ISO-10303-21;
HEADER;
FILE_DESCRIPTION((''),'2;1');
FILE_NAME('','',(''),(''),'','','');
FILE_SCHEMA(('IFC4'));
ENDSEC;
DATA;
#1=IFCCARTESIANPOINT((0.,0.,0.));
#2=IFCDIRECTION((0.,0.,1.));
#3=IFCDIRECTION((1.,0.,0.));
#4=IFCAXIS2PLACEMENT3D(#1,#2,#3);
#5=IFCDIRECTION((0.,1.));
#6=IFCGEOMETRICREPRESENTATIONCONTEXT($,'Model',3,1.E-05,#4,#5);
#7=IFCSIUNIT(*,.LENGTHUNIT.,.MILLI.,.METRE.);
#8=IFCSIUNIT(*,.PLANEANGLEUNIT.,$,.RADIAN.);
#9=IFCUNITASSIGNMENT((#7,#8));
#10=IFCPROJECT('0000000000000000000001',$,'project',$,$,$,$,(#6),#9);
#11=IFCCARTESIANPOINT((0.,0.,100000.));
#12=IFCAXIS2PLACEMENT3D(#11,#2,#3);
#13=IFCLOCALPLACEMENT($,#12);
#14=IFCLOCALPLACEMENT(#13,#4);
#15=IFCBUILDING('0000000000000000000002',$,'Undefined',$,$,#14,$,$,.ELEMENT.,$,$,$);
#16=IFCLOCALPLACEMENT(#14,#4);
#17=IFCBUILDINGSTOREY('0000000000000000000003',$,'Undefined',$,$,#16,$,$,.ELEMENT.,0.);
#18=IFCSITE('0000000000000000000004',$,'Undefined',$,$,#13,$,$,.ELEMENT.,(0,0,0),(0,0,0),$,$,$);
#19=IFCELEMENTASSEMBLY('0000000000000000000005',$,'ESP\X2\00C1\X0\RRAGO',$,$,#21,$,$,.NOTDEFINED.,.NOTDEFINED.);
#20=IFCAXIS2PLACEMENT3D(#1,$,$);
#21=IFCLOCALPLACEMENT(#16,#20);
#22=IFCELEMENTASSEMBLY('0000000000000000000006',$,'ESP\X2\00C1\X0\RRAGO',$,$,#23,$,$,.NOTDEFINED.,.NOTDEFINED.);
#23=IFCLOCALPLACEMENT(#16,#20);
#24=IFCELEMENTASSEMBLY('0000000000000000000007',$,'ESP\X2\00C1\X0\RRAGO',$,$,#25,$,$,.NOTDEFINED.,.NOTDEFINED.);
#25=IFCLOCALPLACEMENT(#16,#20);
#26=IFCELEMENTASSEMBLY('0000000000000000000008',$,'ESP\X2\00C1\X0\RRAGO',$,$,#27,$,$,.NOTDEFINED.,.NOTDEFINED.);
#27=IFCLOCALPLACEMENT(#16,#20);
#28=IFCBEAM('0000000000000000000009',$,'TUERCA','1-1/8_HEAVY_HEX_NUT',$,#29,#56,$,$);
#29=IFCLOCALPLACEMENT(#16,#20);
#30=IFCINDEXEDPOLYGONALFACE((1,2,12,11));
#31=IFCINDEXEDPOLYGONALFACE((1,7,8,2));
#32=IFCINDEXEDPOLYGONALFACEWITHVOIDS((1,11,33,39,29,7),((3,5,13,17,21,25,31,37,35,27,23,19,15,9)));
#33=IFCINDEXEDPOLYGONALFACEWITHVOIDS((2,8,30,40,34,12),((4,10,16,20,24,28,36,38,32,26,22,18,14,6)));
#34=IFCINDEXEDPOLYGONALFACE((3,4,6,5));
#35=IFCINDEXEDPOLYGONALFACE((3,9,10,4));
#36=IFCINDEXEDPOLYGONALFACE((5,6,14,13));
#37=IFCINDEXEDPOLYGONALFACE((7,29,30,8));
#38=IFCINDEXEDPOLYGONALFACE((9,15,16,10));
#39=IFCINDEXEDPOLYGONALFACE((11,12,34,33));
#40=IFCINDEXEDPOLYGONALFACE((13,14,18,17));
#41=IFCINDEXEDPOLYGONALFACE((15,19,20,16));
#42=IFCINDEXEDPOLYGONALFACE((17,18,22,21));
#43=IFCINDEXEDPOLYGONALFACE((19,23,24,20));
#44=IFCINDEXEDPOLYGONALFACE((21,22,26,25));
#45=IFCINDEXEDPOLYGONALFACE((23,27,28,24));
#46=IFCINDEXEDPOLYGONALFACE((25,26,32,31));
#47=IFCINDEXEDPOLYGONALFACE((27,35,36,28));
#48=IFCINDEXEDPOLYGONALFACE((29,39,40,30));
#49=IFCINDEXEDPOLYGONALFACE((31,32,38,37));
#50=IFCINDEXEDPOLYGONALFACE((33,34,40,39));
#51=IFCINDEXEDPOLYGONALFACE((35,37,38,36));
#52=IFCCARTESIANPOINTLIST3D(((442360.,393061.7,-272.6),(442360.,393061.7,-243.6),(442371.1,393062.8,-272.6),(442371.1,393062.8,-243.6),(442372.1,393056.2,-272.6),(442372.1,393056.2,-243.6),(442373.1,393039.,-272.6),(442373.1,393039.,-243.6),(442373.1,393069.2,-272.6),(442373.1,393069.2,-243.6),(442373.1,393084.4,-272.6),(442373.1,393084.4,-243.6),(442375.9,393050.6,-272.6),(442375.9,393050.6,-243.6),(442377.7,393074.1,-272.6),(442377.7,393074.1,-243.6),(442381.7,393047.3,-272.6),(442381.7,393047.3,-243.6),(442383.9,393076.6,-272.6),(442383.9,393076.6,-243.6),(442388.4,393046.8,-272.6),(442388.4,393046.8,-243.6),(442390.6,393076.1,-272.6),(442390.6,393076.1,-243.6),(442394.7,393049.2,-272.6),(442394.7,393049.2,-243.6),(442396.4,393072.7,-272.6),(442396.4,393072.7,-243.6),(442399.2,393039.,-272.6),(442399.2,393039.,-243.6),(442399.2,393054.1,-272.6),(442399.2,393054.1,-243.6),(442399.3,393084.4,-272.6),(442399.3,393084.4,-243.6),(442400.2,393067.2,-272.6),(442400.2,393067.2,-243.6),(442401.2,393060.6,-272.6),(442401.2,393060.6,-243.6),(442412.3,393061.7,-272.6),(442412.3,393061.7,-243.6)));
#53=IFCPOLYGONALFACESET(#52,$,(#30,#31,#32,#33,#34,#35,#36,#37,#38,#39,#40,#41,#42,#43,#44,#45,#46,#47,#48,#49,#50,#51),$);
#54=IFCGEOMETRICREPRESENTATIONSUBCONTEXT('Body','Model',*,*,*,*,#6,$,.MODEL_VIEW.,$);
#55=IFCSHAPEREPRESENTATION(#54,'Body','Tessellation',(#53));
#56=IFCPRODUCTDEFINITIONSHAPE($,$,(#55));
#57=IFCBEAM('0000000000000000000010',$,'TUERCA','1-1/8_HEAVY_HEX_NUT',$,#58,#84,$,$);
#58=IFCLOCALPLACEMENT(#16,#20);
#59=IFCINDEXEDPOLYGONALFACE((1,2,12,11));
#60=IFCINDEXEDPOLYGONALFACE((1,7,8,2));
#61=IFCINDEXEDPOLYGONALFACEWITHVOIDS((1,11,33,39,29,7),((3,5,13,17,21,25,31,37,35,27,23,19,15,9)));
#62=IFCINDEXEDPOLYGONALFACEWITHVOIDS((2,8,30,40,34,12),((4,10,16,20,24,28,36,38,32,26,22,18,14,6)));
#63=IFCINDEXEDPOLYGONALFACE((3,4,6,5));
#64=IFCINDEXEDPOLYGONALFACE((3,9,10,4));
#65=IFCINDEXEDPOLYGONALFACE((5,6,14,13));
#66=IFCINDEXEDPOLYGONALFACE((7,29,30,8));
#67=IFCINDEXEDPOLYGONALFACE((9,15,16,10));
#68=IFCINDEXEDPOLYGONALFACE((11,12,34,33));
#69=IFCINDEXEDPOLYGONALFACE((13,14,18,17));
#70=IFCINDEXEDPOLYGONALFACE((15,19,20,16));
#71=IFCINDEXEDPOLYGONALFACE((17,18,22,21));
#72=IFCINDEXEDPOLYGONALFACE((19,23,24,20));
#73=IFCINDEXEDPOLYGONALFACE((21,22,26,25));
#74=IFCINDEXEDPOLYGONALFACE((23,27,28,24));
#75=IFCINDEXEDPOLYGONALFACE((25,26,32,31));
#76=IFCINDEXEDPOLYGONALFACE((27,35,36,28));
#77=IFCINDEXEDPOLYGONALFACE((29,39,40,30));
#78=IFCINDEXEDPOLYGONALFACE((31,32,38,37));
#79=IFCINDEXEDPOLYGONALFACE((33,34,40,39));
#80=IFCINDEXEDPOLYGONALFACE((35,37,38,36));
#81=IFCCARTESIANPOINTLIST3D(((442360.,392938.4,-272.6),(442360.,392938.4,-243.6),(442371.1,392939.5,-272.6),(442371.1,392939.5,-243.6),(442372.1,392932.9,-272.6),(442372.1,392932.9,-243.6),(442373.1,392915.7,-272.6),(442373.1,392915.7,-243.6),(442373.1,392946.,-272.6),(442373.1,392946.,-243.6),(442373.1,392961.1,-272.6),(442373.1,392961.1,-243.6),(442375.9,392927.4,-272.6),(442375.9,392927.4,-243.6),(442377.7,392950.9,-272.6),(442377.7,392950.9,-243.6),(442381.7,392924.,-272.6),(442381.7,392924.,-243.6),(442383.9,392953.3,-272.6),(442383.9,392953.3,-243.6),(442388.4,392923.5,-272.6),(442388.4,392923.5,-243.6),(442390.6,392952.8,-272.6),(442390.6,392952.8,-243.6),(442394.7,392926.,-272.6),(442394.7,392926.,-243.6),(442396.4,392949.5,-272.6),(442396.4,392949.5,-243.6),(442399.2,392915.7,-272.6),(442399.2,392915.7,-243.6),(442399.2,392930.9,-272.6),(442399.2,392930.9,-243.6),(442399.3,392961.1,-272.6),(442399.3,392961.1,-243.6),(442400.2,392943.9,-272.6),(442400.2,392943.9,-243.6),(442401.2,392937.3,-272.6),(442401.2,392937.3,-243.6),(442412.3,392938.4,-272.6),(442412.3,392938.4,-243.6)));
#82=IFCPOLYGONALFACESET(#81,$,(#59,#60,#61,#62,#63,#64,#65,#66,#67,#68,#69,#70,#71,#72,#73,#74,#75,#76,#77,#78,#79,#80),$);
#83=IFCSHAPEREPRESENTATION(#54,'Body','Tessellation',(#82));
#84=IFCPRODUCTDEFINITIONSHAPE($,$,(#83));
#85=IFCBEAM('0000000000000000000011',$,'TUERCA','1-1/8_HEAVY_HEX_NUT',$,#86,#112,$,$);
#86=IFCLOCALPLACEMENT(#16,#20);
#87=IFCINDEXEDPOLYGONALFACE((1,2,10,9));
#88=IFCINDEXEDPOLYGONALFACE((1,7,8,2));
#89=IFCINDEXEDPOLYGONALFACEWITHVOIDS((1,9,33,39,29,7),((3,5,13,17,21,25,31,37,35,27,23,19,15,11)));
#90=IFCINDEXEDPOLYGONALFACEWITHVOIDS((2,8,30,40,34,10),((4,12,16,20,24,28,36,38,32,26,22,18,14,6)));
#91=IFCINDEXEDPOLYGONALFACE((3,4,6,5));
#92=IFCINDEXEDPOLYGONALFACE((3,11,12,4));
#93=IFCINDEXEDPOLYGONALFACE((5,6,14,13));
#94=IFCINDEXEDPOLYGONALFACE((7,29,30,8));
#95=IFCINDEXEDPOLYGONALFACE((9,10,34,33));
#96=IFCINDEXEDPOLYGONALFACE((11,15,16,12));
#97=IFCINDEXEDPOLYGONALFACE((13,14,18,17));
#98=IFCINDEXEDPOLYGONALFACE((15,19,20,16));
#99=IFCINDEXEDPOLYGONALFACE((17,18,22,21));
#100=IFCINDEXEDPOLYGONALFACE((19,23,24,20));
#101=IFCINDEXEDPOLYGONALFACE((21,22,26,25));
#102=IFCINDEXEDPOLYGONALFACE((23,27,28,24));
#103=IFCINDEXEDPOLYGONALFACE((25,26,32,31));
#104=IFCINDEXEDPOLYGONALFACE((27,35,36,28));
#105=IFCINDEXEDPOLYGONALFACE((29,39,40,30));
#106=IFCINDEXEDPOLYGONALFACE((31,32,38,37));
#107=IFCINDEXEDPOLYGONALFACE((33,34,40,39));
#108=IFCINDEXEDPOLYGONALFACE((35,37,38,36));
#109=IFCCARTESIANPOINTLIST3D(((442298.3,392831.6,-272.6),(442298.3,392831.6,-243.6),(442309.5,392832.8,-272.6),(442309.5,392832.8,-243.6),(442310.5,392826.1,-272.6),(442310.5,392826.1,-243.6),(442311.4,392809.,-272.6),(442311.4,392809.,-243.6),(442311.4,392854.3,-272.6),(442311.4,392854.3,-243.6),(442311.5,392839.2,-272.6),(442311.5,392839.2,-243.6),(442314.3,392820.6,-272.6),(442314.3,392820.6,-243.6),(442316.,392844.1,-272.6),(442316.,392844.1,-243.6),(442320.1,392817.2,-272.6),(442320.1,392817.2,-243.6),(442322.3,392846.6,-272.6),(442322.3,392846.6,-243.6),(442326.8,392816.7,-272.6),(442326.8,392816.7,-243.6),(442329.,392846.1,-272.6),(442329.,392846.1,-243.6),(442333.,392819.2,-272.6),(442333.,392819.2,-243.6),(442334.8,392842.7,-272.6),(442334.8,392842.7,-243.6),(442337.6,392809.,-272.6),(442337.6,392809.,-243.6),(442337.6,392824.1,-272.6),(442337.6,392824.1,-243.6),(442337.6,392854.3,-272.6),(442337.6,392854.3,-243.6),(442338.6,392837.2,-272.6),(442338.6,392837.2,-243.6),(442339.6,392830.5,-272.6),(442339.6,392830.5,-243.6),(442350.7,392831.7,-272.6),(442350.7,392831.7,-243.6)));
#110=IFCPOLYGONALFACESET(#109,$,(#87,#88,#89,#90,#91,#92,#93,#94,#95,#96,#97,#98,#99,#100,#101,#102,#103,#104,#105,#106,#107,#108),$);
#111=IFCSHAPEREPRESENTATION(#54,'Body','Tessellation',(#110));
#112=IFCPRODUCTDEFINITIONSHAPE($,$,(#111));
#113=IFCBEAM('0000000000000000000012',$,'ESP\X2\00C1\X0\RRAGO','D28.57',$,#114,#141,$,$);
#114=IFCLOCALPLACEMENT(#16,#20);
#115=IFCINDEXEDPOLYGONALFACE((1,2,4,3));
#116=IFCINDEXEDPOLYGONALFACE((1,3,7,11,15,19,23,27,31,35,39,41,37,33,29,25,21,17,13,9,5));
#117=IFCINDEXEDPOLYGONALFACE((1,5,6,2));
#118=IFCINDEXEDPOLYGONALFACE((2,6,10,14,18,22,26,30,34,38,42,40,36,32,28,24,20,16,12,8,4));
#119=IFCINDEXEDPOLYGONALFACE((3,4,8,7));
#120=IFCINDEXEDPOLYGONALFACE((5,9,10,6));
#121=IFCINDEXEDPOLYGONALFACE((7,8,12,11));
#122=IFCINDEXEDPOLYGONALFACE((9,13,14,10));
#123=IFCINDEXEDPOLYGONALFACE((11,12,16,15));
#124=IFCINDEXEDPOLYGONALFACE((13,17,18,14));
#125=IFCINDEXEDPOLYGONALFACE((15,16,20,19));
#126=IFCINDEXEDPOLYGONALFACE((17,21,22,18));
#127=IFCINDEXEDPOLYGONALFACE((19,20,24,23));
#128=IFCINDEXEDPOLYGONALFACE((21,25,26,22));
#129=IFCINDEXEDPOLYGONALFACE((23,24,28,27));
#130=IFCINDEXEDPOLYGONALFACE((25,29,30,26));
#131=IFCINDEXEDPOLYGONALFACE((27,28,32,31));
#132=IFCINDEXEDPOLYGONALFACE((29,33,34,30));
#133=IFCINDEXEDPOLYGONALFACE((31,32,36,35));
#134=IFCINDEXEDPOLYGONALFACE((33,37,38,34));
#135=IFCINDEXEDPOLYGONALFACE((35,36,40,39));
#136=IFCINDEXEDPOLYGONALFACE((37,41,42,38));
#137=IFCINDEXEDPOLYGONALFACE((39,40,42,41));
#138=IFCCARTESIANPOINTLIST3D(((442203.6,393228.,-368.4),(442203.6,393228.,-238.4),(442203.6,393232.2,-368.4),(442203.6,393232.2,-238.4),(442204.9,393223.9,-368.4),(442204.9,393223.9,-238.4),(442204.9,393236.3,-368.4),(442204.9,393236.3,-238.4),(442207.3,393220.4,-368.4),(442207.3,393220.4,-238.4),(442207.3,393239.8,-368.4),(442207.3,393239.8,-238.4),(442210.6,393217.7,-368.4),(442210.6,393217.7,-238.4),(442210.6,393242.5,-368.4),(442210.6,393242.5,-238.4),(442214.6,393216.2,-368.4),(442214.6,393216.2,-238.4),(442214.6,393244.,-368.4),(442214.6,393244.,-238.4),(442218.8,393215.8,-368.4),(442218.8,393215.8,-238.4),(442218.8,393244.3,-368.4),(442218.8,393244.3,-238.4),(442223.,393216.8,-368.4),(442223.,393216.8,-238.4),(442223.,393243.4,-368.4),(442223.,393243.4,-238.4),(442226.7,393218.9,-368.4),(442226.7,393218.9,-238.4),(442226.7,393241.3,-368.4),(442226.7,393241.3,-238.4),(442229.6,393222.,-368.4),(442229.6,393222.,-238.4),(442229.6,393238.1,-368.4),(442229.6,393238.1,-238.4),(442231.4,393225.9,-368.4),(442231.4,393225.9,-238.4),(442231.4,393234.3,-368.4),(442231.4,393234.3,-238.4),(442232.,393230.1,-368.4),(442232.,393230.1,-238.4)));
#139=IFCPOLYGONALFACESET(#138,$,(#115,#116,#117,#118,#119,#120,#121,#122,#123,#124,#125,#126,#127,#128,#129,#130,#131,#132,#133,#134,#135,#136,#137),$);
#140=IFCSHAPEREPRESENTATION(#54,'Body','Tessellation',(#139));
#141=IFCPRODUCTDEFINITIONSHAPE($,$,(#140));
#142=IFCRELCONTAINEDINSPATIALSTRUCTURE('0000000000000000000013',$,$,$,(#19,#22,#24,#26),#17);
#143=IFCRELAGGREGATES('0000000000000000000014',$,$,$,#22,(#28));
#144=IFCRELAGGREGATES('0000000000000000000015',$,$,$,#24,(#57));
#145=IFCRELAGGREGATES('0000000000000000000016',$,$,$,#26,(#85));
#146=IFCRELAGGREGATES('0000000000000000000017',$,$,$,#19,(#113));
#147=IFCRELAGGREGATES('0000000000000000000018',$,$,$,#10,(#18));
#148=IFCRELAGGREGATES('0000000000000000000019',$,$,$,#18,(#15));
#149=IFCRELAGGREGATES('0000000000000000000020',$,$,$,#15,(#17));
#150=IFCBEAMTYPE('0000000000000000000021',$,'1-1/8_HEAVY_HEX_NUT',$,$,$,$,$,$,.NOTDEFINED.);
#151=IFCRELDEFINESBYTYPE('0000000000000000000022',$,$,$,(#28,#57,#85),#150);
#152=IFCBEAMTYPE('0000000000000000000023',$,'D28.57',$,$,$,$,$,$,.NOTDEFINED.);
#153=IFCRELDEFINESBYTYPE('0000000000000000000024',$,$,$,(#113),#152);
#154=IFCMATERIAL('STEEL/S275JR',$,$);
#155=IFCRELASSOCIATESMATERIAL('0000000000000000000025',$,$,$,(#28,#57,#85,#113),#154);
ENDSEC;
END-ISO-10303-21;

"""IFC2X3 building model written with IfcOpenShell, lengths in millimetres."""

from ifc_helpers import new_model, si_unit, direction, frame, origin_with_axes, origin_2d_with_axis, place, context, subcontext, project, spatial, polyline, circle, outline, extrude, material, type_object, element, aggregate, save


model = new_model("IFC2X3")

# Units and contexts
model_context = context("Model", 3, precision=1e-05, world=origin_with_axes(), true_north=direction((0.0, 1.0)))
body_context = subcontext(model_context, "Body", "Model", "MODEL_VIEW")
ifc_project = project(units=[si_unit("LENGTHUNIT", "METRE", prefix="MILLI"), si_unit("PLANEANGLEUNIT", "RADIAN")], contexts=[model_context])

# Site, building, storey
site_placement = place(None, frame((0.0, 0.0, 100000.0), z_axis=(0.0, 0.0, 1.0), x_axis=(1.0, 0.0, 0.0)))
site = spatial("IfcSite", under=ifc_project, at=site_placement, Name="Undefined", CompositionType="ELEMENT", RefLatitude=(0, 0, 0), RefLongitude=(0, 0, 0))
building_placement = place(site_placement, origin_with_axes())
building = spatial("IfcBuilding", under=site, at=building_placement, Name="Undefined", CompositionType="ELEMENT")
storey_placement = place(building_placement, origin_with_axes())
storey = spatial("IfcBuildingStorey", under=building, at=storey_placement, Name="Undefined", CompositionType="ELEMENT", Elevation=0.0)

# Shared definitions
ifc_material_1 = material(Name="STEEL/S275JR")

# Element assemblies
beam_type_1 = type_object("IfcBeamType", Name="1-1/8_HEAVY_HEX_NUT", PredefinedType="NOTDEFINED")
assembly_1_placement = place(storey_placement, origin_with_axes())
assembly_1 = element("IfcElementAssembly", 1, at=assembly_1_placement, inside=storey, Name="ESPÁRRAGO", AssemblyPlace="NOTDEFINED", PredefinedType="NOTDEFINED")
assembly_2_placement = place(storey_placement, origin_with_axes())
assembly_2 = element("IfcElementAssembly", 2, at=assembly_2_placement, inside=storey, Name="ESPÁRRAGO", AssemblyPlace="NOTDEFINED", PredefinedType="NOTDEFINED")
assembly_3_placement = place(storey_placement, origin_with_axes())
assembly_3 = element("IfcElementAssembly", 3, at=assembly_3_placement, inside=storey, Name="ESPÁRRAGO", AssemblyPlace="NOTDEFINED", PredefinedType="NOTDEFINED")
assembly_4_placement = place(storey_placement, origin_with_axes())
assembly_4 = element("IfcElementAssembly", 4, at=assembly_4_placement, inside=storey, Name="ESPÁRRAGO", AssemblyPlace="NOTDEFINED", PredefinedType="NOTDEFINED")

# Beams
beam_1_placement = place(assembly_2_placement, frame((442386.2, 393061.7, -243.6), z_axis=(0.866025, -0.5, 0.0), x_axis=(0.0, 0.0, -1.0)))
beam_1 = element("IfcBeam", 5, at=beam_1_placement, type_object=beam_type_1, material=ifc_material_1, Name="TUERCA", Description="1-1/8_HEAVY_HEX_NUT", context=body_context, shape_type="SweptSolid", body=[
    extrude(outline(polyline([(-13.1, -22.7), (-26.2, 0.0), (-13.1, 22.7), (13.1, 22.7), (26.2, 0.0), (13.1, -22.7), (-13.1, -22.7)]), holes=[polyline([(6.5, 13.6), (0.0, 15.1), (-6.5, 13.6), (-11.8, 9.4), (-14.7, 3.4), (-14.7, -3.4), (-11.8, -9.4), (-6.5, -13.6), (0.0, -15.1), (6.5, -13.6), (11.8, -9.4), (14.7, -3.4), (14.7, 3.4), (11.8, 9.4), (6.5, 13.6)])]), frame((29.0, 0.0, 0.0), z_axis=(-1.0, 0.0, 0.0), x_axis=(0.0, -1.0, 0.0)), (0.0, 0.0, 1.0), 29.0),
])
aggregate(assembly_2, [beam_1])
beam_2_placement = place(assembly_3_placement, frame((442386.2, 392938.4, -243.6), z_axis=(0.866025, -0.5, 0.0), x_axis=(0.0, 0.0, -1.0)))
beam_2 = element("IfcBeam", 6, at=beam_2_placement, type_object=beam_type_1, material=ifc_material_1, Name="TUERCA", Description="1-1/8_HEAVY_HEX_NUT", context=body_context, shape_type="SweptSolid", body=[
    extrude(outline(polyline([(-13.1, -22.7), (-26.2, 0.0), (-13.1, 22.7), (13.1, 22.7), (26.2, 0.0), (13.1, -22.7), (-13.1, -22.7)]), holes=[polyline([(6.5, 13.6), (0.0, 15.1), (-6.5, 13.6), (-11.8, 9.4), (-14.7, 3.4), (-14.7, -3.4), (-11.8, -9.4), (-6.5, -13.6), (0.0, -15.1), (6.5, -13.6), (11.8, -9.4), (14.7, -3.4), (14.7, 3.4), (11.8, 9.4), (6.5, 13.6)])]), frame((29.0, 0.0, 0.0), z_axis=(-1.0, 0.0, 0.0), x_axis=(0.0, -1.0, 0.0)), (0.0, 0.0, 1.0), 29.0),
])
aggregate(assembly_3, [beam_2])
beam_3_placement = place(assembly_4_placement, frame((442324.5, 392831.7, -243.6), z_axis=(0.866025, -0.5, 0.0), x_axis=(0.0, 0.0, -1.0)))
beam_3 = element("IfcBeam", 7, at=beam_3_placement, type_object=beam_type_1, material=ifc_material_1, Name="TUERCA", Description="1-1/8_HEAVY_HEX_NUT", context=body_context, shape_type="SweptSolid", body=[
    extrude(outline(polyline([(-13.1, -22.7), (-26.2, 0.0), (-13.1, 22.7), (13.1, 22.7), (26.2, 0.0), (13.1, -22.7), (-13.1, -22.7)]), holes=[polyline([(6.5, 13.6), (0.0, 15.1), (-6.5, 13.6), (-11.8, 9.4), (-14.7, 3.4), (-14.7, -3.4), (-11.8, -9.4), (-6.5, -13.6), (0.0, -15.1), (6.5, -13.6), (11.8, -9.4), (14.7, -3.4), (14.7, 3.4), (11.8, 9.4), (6.5, 13.6)])]), frame((29.0, 0.0, 0.0), z_axis=(-1.0, 0.0, 0.0), x_axis=(0.0, -1.0, 0.0)), (0.0, 0.0, 1.0), 29.0),
])
aggregate(assembly_4, [beam_3])
beam_type_2 = type_object("IfcBeamType", Name="D28.57", PredefinedType="NOTDEFINED")
beam_4_placement = place(assembly_1_placement, frame((442217.8, 393230.1, -238.4), z_axis=(0.866025, -0.5, 0.0), x_axis=(0.0, 0.0, -1.0)))
beam_4 = element("IfcBeam", 8, at=beam_4_placement, type_object=beam_type_2, material=ifc_material_1, Name="ESPÁRRAGO", Description="D28.57", context=body_context, shape_type="SweptSolid", body=[
    extrude(circle(Radius=14.3, at=origin_2d_with_axis()), frame((130.0, 0.0, 0.0), z_axis=(-1.0, 0.0, 0.0), x_axis=(0.0, -1.0, 0.0)), (0.0, 0.0, 1.0), 130.0),
])
aggregate(assembly_1, [beam_4])

save(model, "model.ifc")
